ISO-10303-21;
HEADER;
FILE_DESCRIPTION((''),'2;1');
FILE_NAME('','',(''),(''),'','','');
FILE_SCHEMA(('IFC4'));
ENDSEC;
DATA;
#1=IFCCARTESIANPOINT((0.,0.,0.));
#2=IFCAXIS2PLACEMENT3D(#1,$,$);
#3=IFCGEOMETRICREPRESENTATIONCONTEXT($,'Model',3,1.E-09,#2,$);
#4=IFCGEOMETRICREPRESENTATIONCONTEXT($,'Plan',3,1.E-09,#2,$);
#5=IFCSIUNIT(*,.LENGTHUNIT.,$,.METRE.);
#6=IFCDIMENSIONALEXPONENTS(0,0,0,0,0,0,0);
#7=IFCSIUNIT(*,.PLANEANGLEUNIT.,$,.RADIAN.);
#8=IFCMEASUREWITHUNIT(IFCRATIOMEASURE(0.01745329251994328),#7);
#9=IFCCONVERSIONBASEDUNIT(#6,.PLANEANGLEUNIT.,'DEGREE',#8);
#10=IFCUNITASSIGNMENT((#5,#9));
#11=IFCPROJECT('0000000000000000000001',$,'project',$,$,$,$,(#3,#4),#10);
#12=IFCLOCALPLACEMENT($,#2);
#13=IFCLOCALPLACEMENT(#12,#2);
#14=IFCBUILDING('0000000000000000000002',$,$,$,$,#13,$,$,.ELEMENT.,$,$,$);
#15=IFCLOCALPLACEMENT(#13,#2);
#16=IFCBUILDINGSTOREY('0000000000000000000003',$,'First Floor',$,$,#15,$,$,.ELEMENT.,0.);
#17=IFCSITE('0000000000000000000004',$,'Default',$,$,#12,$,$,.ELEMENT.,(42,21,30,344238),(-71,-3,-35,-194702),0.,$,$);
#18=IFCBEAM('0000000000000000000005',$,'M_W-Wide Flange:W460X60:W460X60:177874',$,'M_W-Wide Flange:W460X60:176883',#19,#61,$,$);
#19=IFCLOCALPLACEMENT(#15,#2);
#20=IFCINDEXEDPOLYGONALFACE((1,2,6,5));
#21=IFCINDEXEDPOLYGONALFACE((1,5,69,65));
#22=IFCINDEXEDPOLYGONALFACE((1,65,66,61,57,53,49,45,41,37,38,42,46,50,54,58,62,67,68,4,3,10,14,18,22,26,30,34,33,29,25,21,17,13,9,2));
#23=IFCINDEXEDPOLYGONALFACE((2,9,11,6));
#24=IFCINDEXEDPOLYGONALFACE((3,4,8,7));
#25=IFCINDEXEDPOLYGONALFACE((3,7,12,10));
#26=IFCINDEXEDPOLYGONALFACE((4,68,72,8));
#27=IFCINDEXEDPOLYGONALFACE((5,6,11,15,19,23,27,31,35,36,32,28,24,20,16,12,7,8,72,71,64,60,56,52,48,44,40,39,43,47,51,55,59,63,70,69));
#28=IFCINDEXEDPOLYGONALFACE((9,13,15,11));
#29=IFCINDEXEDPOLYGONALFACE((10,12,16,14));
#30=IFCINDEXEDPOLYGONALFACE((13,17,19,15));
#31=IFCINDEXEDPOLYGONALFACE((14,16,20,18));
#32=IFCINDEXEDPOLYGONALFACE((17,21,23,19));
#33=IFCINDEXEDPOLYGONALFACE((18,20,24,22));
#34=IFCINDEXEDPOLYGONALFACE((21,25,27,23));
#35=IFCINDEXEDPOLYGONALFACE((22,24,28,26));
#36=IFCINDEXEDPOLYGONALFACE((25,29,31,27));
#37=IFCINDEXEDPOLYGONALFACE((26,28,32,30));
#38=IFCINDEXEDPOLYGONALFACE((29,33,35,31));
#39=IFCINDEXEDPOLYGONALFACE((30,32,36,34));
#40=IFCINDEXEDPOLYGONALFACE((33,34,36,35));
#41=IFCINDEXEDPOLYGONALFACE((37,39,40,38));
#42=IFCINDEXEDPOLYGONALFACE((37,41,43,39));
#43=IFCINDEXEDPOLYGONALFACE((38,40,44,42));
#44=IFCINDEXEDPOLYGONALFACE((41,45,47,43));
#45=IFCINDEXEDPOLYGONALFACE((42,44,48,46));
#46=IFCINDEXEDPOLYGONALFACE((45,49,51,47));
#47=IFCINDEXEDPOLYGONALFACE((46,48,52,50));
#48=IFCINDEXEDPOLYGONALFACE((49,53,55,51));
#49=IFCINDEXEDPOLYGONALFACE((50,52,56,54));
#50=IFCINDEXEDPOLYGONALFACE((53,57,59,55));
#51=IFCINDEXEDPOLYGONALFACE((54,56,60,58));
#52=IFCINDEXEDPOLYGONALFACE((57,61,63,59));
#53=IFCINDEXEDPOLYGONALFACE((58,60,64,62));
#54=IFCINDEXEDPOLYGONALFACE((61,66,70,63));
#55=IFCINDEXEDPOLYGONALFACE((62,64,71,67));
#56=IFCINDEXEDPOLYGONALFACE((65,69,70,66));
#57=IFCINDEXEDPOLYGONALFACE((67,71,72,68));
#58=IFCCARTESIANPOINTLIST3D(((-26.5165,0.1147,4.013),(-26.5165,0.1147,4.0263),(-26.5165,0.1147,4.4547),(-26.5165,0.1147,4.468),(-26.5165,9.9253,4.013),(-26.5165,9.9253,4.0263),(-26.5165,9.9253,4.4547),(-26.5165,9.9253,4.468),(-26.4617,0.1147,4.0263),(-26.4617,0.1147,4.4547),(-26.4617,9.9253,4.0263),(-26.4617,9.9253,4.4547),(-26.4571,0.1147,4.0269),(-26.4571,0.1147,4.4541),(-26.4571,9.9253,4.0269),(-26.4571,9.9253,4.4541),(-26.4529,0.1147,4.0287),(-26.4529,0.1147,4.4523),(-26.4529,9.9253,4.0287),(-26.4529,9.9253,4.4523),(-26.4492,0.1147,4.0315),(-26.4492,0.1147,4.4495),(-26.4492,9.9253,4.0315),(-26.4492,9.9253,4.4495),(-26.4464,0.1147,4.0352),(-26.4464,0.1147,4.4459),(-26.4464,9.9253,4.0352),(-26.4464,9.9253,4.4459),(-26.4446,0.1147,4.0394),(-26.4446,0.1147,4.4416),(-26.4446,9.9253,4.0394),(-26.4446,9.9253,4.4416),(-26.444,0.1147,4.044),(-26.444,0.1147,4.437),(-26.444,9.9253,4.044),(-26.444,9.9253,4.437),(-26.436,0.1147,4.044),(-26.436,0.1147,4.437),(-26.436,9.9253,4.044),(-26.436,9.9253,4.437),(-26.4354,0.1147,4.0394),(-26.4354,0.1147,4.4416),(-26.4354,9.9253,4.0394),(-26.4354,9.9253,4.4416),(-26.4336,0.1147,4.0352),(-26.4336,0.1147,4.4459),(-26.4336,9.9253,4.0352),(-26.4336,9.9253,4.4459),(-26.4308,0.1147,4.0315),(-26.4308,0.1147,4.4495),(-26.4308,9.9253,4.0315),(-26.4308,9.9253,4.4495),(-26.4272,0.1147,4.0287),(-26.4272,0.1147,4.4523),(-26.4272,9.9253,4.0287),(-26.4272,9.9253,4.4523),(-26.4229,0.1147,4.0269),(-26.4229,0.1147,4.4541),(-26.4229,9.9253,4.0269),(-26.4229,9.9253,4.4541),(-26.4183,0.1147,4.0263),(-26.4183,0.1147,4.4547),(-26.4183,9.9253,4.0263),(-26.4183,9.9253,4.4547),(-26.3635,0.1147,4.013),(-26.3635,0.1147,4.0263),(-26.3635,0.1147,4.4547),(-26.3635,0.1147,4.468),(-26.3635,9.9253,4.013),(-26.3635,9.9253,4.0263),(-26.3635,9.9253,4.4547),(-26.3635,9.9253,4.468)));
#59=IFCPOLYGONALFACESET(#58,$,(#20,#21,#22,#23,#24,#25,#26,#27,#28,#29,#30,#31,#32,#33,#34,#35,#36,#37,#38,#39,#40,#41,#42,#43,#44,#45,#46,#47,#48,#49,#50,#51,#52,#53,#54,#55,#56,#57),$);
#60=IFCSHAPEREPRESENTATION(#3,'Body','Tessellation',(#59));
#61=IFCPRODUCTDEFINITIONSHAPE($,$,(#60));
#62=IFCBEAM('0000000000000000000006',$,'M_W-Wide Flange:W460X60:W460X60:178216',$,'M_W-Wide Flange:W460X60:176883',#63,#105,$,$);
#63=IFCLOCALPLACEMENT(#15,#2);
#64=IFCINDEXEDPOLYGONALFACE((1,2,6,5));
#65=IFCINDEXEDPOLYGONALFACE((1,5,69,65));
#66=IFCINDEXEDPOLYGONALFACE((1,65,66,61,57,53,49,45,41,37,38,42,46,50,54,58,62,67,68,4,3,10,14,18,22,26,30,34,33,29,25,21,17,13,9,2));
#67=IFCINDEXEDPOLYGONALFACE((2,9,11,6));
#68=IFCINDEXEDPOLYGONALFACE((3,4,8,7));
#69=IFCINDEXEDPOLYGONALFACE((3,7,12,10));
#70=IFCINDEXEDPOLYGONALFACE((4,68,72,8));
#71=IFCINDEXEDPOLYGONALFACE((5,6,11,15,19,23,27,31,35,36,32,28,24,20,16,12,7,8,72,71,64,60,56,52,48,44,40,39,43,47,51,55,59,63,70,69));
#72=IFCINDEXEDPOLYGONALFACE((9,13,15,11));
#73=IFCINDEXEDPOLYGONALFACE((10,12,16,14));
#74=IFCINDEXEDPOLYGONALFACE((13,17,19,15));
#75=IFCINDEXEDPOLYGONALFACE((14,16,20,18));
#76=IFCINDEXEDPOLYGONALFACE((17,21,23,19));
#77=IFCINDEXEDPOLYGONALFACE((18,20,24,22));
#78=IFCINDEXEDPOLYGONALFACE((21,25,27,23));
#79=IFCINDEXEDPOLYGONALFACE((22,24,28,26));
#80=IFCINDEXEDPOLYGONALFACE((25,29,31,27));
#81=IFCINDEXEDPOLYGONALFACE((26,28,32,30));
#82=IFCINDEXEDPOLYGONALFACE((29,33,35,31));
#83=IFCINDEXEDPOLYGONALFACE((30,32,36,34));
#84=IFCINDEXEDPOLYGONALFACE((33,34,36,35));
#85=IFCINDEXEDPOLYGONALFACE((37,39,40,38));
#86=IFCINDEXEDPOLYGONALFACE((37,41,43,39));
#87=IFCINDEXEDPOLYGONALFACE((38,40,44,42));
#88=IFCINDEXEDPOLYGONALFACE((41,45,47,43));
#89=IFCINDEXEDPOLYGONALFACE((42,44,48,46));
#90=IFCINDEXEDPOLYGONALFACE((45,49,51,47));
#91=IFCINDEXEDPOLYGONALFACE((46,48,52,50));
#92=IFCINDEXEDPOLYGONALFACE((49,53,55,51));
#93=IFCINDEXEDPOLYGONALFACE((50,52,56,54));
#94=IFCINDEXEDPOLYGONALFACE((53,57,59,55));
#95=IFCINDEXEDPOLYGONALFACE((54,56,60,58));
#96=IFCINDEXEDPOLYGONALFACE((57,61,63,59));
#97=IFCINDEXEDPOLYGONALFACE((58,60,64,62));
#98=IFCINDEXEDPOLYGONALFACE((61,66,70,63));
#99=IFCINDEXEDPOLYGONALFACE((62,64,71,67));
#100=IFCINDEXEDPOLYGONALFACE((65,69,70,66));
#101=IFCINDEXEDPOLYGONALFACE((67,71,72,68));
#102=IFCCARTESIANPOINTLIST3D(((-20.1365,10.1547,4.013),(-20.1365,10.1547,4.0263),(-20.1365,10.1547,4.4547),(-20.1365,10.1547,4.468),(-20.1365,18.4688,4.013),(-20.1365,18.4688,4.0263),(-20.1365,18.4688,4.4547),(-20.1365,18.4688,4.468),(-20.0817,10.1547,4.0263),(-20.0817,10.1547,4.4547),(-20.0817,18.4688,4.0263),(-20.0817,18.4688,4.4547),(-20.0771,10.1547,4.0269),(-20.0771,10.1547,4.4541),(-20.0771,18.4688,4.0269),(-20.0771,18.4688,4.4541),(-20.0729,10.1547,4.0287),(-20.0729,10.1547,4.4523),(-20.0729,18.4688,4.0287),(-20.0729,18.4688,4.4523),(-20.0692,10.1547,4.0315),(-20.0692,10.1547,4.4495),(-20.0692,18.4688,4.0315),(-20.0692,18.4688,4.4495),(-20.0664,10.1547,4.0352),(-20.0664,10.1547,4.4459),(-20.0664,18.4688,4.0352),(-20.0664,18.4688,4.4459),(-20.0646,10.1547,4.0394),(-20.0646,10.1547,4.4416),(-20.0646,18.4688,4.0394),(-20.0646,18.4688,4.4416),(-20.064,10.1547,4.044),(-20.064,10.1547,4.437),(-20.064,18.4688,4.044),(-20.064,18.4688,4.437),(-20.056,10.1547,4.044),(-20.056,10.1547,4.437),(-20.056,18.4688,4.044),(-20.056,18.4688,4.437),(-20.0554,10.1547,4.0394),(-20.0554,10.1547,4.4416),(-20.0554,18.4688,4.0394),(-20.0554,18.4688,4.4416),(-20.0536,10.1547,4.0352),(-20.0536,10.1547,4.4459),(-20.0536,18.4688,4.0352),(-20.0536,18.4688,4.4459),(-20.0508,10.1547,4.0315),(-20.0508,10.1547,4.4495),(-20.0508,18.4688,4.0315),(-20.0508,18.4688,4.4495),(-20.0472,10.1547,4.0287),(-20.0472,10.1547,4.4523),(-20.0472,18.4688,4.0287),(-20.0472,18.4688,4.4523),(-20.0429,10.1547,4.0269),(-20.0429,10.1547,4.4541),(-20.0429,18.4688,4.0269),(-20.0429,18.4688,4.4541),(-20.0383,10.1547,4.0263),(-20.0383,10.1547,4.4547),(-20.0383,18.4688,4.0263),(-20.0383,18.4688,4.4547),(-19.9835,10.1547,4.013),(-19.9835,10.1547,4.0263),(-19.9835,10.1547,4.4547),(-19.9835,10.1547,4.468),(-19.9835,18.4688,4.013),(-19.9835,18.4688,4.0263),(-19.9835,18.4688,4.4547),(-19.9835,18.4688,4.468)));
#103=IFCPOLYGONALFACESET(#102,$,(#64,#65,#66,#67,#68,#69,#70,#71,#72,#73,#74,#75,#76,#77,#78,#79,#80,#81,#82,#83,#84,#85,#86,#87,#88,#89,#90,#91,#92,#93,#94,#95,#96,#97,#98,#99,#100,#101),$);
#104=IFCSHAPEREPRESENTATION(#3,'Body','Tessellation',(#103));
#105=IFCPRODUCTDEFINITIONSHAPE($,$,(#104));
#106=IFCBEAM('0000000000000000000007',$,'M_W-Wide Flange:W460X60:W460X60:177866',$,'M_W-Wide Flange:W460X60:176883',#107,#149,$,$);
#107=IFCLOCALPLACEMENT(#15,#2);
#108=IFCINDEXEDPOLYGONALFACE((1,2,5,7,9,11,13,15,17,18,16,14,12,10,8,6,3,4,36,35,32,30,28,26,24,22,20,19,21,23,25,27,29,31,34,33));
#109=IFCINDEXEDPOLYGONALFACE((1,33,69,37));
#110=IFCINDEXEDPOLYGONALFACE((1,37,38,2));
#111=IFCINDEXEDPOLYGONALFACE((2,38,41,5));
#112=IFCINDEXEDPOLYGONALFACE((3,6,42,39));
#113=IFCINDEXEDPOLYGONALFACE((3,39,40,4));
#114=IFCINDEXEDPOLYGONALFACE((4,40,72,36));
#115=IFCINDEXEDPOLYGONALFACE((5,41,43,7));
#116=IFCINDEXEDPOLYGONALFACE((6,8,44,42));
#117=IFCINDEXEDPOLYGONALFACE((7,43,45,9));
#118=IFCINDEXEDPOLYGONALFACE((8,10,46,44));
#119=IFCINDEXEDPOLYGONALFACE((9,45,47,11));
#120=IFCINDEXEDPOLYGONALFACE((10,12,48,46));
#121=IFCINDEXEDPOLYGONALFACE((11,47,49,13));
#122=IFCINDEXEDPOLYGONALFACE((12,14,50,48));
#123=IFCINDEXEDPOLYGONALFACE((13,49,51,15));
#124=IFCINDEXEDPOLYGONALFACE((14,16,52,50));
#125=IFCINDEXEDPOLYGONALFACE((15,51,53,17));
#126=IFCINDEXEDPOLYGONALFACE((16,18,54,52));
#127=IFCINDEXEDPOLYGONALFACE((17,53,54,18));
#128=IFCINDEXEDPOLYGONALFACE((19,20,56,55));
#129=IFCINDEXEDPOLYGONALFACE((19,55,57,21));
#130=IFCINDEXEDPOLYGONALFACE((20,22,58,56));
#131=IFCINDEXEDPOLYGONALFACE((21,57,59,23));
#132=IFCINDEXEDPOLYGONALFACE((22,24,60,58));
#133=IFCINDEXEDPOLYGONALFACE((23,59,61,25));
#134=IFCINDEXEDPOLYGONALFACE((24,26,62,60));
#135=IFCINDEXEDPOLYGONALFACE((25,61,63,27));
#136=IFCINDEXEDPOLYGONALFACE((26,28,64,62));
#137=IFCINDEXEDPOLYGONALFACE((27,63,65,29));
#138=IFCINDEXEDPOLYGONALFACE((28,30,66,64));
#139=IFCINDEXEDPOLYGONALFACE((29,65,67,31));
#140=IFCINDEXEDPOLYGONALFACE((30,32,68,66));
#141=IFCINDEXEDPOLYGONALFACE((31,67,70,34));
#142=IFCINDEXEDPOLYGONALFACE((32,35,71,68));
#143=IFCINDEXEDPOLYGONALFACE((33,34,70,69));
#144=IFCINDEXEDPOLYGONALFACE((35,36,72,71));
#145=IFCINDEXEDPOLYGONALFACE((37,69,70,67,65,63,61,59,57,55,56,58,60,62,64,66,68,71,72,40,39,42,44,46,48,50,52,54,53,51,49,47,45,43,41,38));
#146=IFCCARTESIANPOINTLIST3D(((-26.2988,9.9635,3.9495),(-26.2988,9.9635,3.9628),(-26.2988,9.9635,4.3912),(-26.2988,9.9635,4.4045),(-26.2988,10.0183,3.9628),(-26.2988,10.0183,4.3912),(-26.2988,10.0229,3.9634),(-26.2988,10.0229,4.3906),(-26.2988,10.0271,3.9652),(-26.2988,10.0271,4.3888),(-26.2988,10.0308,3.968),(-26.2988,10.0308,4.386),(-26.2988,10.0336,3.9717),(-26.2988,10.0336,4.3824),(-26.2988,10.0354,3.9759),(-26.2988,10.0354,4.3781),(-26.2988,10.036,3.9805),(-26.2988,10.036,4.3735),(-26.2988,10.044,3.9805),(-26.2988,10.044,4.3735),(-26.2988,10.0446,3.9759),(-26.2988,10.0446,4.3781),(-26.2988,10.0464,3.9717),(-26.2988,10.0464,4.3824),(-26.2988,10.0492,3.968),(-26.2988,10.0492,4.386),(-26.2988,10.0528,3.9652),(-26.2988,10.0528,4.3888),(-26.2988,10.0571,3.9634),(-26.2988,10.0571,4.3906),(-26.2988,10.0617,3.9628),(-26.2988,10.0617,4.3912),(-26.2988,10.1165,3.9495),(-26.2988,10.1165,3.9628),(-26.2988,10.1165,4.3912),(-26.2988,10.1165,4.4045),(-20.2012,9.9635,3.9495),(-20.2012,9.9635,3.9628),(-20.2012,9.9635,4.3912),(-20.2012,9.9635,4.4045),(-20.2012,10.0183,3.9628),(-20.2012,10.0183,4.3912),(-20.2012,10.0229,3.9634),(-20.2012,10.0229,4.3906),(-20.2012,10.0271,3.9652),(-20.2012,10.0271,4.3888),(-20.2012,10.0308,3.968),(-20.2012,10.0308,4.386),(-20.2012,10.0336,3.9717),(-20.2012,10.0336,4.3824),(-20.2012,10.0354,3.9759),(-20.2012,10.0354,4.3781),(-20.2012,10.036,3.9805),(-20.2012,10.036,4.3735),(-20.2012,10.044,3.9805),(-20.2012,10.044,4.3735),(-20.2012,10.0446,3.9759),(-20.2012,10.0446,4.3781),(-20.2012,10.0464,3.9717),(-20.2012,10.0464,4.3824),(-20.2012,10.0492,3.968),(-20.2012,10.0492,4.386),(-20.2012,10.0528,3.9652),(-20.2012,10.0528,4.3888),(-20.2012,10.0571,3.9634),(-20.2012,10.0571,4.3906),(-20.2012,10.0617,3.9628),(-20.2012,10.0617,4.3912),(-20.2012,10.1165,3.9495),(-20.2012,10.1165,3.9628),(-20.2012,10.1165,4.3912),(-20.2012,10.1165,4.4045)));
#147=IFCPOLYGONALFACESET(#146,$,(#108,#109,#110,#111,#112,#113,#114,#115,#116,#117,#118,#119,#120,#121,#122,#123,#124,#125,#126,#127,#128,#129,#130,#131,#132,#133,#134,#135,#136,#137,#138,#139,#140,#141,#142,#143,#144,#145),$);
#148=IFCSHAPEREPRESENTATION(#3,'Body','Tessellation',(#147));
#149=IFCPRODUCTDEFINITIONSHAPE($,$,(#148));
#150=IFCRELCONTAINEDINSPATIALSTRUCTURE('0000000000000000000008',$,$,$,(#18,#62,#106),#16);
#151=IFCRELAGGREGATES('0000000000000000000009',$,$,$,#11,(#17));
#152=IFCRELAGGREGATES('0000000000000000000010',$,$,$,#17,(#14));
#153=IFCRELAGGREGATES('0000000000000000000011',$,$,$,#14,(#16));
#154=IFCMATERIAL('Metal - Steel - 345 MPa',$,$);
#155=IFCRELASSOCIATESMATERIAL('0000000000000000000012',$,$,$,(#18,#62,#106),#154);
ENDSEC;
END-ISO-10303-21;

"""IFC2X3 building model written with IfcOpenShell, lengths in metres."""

from ifc_helpers import new_model, entity, si_unit, converted_unit, frame, frame_2d, origin, place, context, project, spatial, polyline, circle_curve, parameter, trimmed, segment, composite_curve, outline, extrude, material, element, save


model = new_model("IFC2X3")

# Units and contexts
model_context = context("Model", 3, precision=1e-09, world=origin())
plan_context = context("Plan", 3, precision=1e-09, world=origin())
ifc_project = project(units=[si_unit("LENGTHUNIT", "METRE"), converted_unit("PLANEANGLEUNIT", "DEGREE", entity("IfcRatioMeasure", 0.01745329251994328), si_unit("PLANEANGLEUNIT", "RADIAN"), dimensions=[0, 0, 0, 0, 0, 0, 0])], contexts=[model_context, plan_context])

# Site, building, storey
site_placement = place(None, origin())
site = spatial("IfcSite", under=ifc_project, at=site_placement, Name="Default", CompositionType="ELEMENT", RefLatitude=(42, 21, 30, 344238), RefLongitude=(-71, -3, -35, -194702), RefElevation=0.0)
building_placement = place(site_placement, origin())
building = spatial("IfcBuilding", under=site, at=building_placement, CompositionType="ELEMENT")
storey_placement = place(building_placement, origin())
storey = spatial("IfcBuildingStorey", under=building, at=storey_placement, Name="First Floor", CompositionType="ELEMENT", Elevation=0.0)

# Beams
ifc_material_1 = material(Name="Metal - Steel - 345 MPa")
beam_1_placement = place(storey_placement, frame((-26.44, 10.0414, 4.468), z_axis=(0.0, 0.0, 1.0), x_axis=(-1.0, 0.0, 0.0)))
element("IfcBeam", 1, at=beam_1_placement, inside=storey, material=ifc_material_1, Name="M_W-Wide Flange:W460X60:W460X60:177874", ObjectType="M_W-Wide Flange:W460X60:176883", context=model_context, shape_type="SweptSolid", body=[
    extrude(outline(composite_curve([segment(polyline([(0.2142, -0.0765), (0.2275, -0.0765)]), True, "CONTINUOUS"), segment(polyline([(0.2275, -0.0765), (0.2275, 0.0765)]), True, "CONTINUOUS"), segment(polyline([(0.2275, 0.0765), (0.2142, 0.0765)]), True, "CONTINUOUS"), segment(polyline([(0.2142, 0.0765), (0.2142, 0.0217)]), True, "CONTINUOUS"), segment(trimmed(circle_curve(frame_2d((0.1965, 0.0217), x_axis=(1.0, 0.0)), 0.0177), [parameter(270.0)], [parameter(360.0)], True, "PARAMETER"), False, "CONTINUOUS"), segment(polyline([(0.1965, 0.004), (-0.1965, 0.004)]), True, "CONTINUOUS"), segment(trimmed(circle_curve(frame_2d((-0.1965, 0.0217), x_axis=(0.0, -1.0)), 0.0177), [parameter(270.0)], [parameter(360.0)], True, "PARAMETER"), False, "CONTINUOUS"), segment(polyline([(-0.2142, 0.0217), (-0.2142, 0.0765)]), True, "CONTINUOUS"), segment(polyline([(-0.2142, 0.0765), (-0.2275, 0.0765)]), True, "CONTINUOUS"), segment(polyline([(-0.2275, 0.0765), (-0.2275, -0.0765)]), True, "CONTINUOUS"), segment(polyline([(-0.2275, -0.0765), (-0.2142, -0.0765)]), True, "CONTINUOUS"), segment(polyline([(-0.2142, -0.0765), (-0.2142, -0.0217)]), True, "CONTINUOUS"), segment(trimmed(circle_curve(frame_2d((-0.1965, -0.0217), x_axis=(-1.0, 0.0)), 0.0177), [parameter(270.0)], [parameter(360.0)], True, "PARAMETER"), False, "CONTINUOUS"), segment(polyline([(-0.1965, -0.004), (0.1965, -0.004)]), True, "CONTINUOUS"), segment(trimmed(circle_curve(frame_2d((0.1965, -0.0217), x_axis=(0.0, 1.0)), 0.0177), [parameter(270.0)], [parameter(0.0)], True, "PARAMETER"), False, "CONTINUOUS"), segment(polyline([(0.2142, -0.0217), (0.2142, -0.0765)]), True, "CONTINUOUS")], self_intersect=False)), frame((0.0, 9.9267, -0.2275), z_axis=(0.0, -1.0, 0.0), x_axis=(0.0, 0.0, -1.0)), (0.0, 0.0, 1.0), 9.8106),
])
beam_2_placement = place(storey_placement, frame((-20.06, 10.0384, 4.468)))
element("IfcBeam", 2, at=beam_2_placement, inside=storey, material=ifc_material_1, Name="M_W-Wide Flange:W460X60:W460X60:178216", ObjectType="M_W-Wide Flange:W460X60:176883", context=model_context, shape_type="SweptSolid", body=[
    extrude(outline(composite_curve([segment(polyline([(-0.0765, -0.2142), (-0.0765, -0.2275)]), True, "CONTINUOUS"), segment(polyline([(-0.0765, -0.2275), (0.0765, -0.2275)]), True, "CONTINUOUS"), segment(polyline([(0.0765, -0.2275), (0.0765, -0.2142)]), True, "CONTINUOUS"), segment(polyline([(0.0765, -0.2142), (0.0217, -0.2142)]), True, "CONTINUOUS"), segment(trimmed(circle_curve(frame_2d((0.0217, -0.1965), x_axis=(0.0, -1.0)), 0.0177), [parameter(270.0)], [parameter(360.0)], True, "PARAMETER"), False, "CONTINUOUS"), segment(polyline([(0.004, -0.1965), (0.004, 0.1965)]), True, "CONTINUOUS"), segment(trimmed(circle_curve(frame_2d((0.0217, 0.1965), x_axis=(-1.0, 0.0)), 0.0177), [parameter(270.0)], [parameter(360.0)], True, "PARAMETER"), False, "CONTINUOUS"), segment(polyline([(0.0217, 0.2142), (0.0765, 0.2142)]), True, "CONTINUOUS"), segment(polyline([(0.0765, 0.2142), (0.0765, 0.2275)]), True, "CONTINUOUS"), segment(polyline([(0.0765, 0.2275), (-0.0765, 0.2275)]), True, "CONTINUOUS"), segment(polyline([(-0.0765, 0.2275), (-0.0765, 0.2142)]), True, "CONTINUOUS"), segment(polyline([(-0.0765, 0.2142), (-0.0217, 0.2142)]), True, "CONTINUOUS"), segment(trimmed(circle_curve(frame_2d((-0.0217, 0.1965), x_axis=(0.0, 1.0)), 0.0177), [parameter(270.0)], [parameter(360.0)], True, "PARAMETER"), False, "CONTINUOUS"), segment(polyline([(-0.004, 0.1965), (-0.004, -0.1965)]), True, "CONTINUOUS"), segment(trimmed(circle_curve(frame_2d((-0.0217, -0.1965), x_axis=(1.0, 0.0)), 0.0177), [parameter(270.0)], [parameter(0.0)], True, "PARAMETER"), False, "CONTINUOUS"), segment(polyline([(-0.0217, -0.2142), (-0.0765, -0.2142)]), True, "CONTINUOUS")], self_intersect=False)), frame((0.0, 0.1163, -0.2275), z_axis=(0.0, -1.0, 0.0), x_axis=(1.0, 0.0, 0.0)), (0.0, 0.0, -1.0), 8.3141),
])
beam_3_placement = place(storey_placement, frame((-20.0579, 10.04, 4.4045), z_axis=(0.0, 0.0, 1.0), x_axis=(0.0, 1.0, 0.0)))
element("IfcBeam", 3, at=beam_3_placement, inside=storey, material=ifc_material_1, Name="M_W-Wide Flange:W460X60:W460X60:177866", ObjectType="M_W-Wide Flange:W460X60:176883", context=model_context, shape_type="SweptSolid", body=[
    extrude(outline(composite_curve([segment(polyline([(0.2142, -0.0765), (0.2275, -0.0765)]), True, "CONTINUOUS"), segment(polyline([(0.2275, -0.0765), (0.2275, 0.0765)]), True, "CONTINUOUS"), segment(polyline([(0.2275, 0.0765), (0.2142, 0.0765)]), True, "CONTINUOUS"), segment(polyline([(0.2142, 0.0765), (0.2142, 0.0217)]), True, "CONTINUOUS"), segment(trimmed(circle_curve(frame_2d((0.1965, 0.0217), x_axis=(1.0, 0.0)), 0.0177), [parameter(270.0)], [parameter(360.0)], True, "PARAMETER"), False, "CONTINUOUS"), segment(polyline([(0.1965, 0.004), (-0.1965, 0.004)]), True, "CONTINUOUS"), segment(trimmed(circle_curve(frame_2d((-0.1965, 0.0217), x_axis=(0.0, -1.0)), 0.0177), [parameter(270.0)], [parameter(360.0)], True, "PARAMETER"), False, "CONTINUOUS"), segment(polyline([(-0.2142, 0.0217), (-0.2142, 0.0765)]), True, "CONTINUOUS"), segment(polyline([(-0.2142, 0.0765), (-0.2275, 0.0765)]), True, "CONTINUOUS"), segment(polyline([(-0.2275, 0.0765), (-0.2275, -0.0765)]), True, "CONTINUOUS"), segment(polyline([(-0.2275, -0.0765), (-0.2142, -0.0765)]), True, "CONTINUOUS"), segment(polyline([(-0.2142, -0.0765), (-0.2142, -0.0217)]), True, "CONTINUOUS"), segment(trimmed(circle_curve(frame_2d((-0.1965, -0.0217), x_axis=(-1.0, 0.0)), 0.0177), [parameter(270.0)], [parameter(360.0)], True, "PARAMETER"), False, "CONTINUOUS"), segment(polyline([(-0.1965, -0.004), (0.1965, -0.004)]), True, "CONTINUOUS"), segment(trimmed(circle_curve(frame_2d((0.1965, -0.0217), x_axis=(0.0, 1.0)), 0.0177), [parameter(270.0)], [parameter(0.0)], True, "PARAMETER"), False, "CONTINUOUS"), segment(polyline([(0.2142, -0.0217), (0.2142, -0.0765)]), True, "CONTINUOUS")], self_intersect=False)), frame((0.0, 6.2409, -0.2275), z_axis=(0.0, -1.0, 0.0), x_axis=(0.0, 0.0, -1.0)), (0.0, 0.0, 1.0), 6.0976),
])

save(model, "model.ifc")
